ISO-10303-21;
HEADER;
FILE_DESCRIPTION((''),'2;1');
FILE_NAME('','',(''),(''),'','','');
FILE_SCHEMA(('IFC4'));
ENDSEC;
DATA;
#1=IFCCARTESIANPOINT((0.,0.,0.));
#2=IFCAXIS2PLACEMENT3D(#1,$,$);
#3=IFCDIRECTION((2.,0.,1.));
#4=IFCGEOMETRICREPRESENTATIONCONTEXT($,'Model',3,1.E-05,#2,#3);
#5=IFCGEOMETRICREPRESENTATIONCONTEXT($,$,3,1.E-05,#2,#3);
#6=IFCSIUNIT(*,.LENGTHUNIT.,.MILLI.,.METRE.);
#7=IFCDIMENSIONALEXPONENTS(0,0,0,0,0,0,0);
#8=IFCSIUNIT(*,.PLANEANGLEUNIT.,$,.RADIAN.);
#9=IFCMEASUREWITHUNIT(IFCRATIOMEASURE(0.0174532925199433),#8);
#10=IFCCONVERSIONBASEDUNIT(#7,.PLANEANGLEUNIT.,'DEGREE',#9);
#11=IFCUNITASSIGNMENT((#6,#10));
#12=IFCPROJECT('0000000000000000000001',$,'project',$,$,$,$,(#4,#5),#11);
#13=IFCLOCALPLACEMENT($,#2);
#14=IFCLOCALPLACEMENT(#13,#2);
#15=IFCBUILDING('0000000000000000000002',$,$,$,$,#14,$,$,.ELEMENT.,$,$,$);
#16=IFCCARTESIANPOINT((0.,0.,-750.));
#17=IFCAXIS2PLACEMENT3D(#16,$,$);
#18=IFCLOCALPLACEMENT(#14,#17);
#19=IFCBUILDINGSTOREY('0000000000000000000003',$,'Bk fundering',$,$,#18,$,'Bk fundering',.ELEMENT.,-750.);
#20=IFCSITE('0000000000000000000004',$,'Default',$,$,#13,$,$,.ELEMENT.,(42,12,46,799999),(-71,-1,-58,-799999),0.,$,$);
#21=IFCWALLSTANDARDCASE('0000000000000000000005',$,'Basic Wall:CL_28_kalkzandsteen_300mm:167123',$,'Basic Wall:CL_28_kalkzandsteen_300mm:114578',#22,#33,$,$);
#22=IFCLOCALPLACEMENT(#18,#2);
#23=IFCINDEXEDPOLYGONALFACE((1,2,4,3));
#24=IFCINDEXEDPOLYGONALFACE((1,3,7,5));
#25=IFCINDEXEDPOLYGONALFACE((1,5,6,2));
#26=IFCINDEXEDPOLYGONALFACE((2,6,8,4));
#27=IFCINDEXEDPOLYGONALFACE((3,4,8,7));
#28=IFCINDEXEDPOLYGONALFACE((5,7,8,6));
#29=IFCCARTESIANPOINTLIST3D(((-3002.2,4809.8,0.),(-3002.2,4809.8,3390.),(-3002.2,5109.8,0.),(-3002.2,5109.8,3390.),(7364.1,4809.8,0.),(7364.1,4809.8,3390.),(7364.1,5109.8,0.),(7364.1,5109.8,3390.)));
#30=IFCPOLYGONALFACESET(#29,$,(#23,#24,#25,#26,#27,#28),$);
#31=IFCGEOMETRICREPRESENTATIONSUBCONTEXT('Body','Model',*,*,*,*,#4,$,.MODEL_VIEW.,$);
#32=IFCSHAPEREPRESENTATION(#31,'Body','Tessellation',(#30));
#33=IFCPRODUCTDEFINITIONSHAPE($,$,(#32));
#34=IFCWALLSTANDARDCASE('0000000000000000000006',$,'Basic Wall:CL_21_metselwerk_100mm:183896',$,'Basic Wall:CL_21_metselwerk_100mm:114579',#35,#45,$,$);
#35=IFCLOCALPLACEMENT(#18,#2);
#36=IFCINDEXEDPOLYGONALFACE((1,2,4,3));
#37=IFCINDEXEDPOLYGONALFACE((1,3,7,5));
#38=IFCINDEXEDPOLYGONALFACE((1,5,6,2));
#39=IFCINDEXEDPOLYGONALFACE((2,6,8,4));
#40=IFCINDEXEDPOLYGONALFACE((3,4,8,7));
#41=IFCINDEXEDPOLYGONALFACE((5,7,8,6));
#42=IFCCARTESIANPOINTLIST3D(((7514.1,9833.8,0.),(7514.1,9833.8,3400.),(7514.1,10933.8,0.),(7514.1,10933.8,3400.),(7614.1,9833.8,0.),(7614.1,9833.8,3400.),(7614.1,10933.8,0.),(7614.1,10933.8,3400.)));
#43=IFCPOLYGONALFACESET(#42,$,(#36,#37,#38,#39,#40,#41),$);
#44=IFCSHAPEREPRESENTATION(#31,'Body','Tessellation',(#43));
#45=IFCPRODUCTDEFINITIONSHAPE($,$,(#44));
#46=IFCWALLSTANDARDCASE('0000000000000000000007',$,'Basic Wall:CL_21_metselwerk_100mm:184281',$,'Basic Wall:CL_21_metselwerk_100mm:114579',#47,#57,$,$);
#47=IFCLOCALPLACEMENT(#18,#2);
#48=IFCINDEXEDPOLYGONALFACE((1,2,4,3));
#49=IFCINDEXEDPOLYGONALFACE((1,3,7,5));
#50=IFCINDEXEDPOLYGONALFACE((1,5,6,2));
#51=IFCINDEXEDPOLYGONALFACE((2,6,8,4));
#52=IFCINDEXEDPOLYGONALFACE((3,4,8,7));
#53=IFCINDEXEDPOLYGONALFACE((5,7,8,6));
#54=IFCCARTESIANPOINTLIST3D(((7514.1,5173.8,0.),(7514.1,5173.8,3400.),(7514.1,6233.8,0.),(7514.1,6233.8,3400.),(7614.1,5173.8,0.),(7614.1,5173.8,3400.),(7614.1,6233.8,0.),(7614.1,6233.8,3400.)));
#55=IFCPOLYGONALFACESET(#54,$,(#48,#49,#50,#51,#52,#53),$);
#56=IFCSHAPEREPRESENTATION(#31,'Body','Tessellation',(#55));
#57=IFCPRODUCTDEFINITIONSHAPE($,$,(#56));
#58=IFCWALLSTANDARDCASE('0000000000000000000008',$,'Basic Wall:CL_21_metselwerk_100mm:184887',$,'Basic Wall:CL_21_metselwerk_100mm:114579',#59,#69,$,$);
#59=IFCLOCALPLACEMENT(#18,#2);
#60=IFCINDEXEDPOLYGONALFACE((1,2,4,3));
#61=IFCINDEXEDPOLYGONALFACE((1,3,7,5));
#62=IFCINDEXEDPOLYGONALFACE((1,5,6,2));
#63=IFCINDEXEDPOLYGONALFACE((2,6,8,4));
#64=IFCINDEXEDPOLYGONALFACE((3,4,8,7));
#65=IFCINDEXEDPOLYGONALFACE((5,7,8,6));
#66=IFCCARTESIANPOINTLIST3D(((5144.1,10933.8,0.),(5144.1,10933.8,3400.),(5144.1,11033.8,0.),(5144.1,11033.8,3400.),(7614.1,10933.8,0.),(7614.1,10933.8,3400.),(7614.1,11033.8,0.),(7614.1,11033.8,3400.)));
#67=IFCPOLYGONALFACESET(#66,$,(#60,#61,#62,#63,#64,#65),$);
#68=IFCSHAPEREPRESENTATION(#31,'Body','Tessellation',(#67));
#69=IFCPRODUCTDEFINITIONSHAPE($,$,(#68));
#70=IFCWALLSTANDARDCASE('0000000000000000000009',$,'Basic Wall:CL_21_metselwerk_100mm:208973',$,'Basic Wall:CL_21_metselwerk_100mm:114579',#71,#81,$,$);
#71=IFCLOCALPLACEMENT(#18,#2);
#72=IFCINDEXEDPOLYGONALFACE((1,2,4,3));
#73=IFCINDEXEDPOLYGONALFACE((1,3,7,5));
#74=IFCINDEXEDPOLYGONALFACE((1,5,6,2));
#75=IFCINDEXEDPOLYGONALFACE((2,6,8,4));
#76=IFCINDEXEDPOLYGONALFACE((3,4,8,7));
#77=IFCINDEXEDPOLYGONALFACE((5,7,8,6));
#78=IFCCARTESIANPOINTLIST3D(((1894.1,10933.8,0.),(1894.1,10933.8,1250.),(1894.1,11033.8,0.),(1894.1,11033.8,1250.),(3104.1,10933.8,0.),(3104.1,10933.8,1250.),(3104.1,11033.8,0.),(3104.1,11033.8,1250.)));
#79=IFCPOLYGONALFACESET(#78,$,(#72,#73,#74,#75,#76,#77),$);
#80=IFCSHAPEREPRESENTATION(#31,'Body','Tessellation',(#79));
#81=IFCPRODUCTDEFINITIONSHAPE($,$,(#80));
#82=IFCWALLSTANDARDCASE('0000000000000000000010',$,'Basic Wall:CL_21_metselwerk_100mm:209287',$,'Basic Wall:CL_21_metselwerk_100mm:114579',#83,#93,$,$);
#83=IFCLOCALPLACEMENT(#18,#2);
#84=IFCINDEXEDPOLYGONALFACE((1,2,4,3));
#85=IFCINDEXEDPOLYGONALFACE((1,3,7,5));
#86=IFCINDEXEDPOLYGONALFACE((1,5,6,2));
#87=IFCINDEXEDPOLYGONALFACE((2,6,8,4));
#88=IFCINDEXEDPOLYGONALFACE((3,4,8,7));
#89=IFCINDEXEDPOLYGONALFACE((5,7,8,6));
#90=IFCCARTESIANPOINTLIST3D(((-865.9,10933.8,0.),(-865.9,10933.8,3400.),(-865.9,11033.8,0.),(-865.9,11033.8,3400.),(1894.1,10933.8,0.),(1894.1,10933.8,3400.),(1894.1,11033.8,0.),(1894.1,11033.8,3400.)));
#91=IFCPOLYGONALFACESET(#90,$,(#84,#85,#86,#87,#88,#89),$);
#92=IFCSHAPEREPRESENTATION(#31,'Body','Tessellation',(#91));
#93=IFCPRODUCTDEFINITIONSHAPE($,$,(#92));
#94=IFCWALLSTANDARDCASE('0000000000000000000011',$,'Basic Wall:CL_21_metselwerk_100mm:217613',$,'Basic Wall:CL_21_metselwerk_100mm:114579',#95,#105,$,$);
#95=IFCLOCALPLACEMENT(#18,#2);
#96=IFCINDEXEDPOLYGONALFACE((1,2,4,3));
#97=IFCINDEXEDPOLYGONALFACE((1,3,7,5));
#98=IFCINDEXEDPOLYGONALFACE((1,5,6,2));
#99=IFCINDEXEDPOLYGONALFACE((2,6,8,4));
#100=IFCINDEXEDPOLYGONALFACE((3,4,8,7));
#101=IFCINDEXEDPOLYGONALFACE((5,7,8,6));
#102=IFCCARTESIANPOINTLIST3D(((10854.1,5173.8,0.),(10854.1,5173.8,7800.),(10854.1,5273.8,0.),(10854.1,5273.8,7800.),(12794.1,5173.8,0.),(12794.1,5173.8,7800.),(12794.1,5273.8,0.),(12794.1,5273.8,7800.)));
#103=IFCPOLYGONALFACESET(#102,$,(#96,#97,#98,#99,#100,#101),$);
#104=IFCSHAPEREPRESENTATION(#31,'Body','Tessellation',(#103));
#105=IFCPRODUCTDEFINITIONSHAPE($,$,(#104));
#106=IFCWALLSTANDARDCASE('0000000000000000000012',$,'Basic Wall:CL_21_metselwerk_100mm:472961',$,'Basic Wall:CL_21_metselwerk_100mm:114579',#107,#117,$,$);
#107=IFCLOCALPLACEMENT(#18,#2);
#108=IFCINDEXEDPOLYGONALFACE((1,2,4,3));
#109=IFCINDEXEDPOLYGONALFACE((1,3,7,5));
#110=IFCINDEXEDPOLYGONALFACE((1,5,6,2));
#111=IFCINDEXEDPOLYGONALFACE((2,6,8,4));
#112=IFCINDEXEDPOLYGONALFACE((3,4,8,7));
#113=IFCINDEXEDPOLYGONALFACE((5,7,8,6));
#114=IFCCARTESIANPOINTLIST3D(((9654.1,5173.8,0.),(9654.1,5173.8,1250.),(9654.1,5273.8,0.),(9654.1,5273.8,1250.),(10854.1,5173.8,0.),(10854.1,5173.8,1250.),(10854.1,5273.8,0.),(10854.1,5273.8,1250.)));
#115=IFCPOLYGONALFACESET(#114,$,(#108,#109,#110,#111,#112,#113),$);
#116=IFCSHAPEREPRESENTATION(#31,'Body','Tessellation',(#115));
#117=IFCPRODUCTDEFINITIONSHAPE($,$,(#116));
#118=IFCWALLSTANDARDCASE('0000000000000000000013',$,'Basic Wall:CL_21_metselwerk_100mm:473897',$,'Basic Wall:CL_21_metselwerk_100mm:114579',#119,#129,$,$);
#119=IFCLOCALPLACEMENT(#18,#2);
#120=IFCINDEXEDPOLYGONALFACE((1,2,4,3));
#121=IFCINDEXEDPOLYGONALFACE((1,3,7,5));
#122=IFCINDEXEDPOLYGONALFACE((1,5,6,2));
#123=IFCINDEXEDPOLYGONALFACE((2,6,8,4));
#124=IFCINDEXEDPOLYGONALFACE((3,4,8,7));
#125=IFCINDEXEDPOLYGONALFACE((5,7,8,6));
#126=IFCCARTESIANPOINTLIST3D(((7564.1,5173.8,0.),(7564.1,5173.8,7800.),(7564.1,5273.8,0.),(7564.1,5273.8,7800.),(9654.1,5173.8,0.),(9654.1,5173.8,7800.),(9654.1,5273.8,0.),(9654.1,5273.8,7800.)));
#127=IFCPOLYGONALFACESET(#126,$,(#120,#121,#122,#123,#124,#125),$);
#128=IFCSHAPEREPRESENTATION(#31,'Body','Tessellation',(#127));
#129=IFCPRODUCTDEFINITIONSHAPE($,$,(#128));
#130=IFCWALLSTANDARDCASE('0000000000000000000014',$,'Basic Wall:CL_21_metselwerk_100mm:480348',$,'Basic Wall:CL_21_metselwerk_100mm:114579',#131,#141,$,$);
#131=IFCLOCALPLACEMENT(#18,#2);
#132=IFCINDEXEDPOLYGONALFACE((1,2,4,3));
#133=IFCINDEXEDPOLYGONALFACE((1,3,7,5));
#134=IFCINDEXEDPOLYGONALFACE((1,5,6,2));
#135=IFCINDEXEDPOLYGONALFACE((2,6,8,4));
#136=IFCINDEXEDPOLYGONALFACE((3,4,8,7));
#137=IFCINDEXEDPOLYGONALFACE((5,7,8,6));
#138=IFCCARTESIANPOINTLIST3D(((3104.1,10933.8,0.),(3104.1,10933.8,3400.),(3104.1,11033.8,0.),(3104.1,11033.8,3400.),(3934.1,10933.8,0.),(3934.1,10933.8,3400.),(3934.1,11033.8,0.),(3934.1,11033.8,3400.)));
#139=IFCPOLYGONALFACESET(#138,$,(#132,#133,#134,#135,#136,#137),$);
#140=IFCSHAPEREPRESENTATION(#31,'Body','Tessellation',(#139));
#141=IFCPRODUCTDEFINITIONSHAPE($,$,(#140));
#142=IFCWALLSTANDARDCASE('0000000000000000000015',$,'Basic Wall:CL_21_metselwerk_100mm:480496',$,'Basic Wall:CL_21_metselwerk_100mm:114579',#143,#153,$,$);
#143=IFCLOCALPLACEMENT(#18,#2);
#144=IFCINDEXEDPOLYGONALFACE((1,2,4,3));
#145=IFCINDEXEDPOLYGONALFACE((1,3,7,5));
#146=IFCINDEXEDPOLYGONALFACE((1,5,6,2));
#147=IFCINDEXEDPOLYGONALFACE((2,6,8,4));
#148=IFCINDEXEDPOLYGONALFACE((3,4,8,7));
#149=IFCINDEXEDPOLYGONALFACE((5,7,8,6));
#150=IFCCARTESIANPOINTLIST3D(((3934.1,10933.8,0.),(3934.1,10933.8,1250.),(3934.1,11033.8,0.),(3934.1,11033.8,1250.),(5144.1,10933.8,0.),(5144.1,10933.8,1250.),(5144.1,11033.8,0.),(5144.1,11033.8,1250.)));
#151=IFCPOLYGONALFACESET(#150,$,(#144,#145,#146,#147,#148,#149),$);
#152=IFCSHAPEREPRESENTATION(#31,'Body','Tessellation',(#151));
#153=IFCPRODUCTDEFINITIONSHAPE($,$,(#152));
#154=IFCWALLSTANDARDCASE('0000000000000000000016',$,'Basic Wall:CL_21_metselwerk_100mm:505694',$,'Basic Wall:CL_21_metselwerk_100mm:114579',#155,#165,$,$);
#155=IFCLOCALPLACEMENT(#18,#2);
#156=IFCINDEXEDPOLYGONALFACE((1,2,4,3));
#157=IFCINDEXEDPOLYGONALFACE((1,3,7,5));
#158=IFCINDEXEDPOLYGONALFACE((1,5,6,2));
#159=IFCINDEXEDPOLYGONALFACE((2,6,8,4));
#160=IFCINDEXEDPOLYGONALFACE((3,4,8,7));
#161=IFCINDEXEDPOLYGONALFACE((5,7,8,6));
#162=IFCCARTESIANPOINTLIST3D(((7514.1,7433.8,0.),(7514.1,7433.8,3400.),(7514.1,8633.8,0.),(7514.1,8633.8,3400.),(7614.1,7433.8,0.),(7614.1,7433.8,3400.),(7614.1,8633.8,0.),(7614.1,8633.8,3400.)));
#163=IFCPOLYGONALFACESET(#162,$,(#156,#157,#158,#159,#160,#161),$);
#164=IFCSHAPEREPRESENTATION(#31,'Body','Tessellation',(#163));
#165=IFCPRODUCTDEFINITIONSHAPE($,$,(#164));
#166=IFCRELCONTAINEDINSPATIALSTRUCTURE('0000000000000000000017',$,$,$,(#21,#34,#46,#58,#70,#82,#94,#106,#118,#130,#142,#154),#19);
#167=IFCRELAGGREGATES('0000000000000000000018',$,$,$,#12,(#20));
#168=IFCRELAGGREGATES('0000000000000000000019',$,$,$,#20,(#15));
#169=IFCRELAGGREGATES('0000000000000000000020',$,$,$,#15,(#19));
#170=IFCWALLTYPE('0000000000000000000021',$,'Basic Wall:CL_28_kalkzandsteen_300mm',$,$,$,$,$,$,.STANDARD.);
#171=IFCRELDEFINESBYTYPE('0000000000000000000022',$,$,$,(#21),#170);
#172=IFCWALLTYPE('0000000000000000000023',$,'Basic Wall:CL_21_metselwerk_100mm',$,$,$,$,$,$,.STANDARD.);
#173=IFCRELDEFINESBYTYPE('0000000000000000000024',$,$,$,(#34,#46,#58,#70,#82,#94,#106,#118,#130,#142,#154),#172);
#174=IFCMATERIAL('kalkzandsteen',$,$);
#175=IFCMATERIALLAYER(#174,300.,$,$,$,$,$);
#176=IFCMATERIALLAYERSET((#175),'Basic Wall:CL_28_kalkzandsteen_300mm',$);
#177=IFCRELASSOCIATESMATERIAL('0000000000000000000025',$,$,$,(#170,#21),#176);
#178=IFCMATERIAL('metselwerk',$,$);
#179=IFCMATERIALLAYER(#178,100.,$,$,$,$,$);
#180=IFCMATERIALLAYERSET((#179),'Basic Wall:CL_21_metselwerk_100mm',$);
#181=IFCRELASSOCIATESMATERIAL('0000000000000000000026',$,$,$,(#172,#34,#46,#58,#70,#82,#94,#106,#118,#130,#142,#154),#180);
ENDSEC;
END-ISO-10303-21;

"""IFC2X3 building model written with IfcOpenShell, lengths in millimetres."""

from ifc_helpers import new_model, entity, si_unit, converted_unit, direction, frame, frame_2d, origin, place, context, subcontext, project, spatial, polyline, rectangle, extrude, clip, bounded_halfspace, material, layer, layer_set, layer_usage, type_object, element, save


model = new_model("IFC2X3")

# Units and contexts
model_context = context("Model", 3, precision=1e-05, world=origin(), true_north=direction((2.0, 0.0, 1.0)))
context_of_model = context(None, 3, precision=1e-05, world=origin(), true_north=direction((2.0, 0.0, 1.0)))
body_context = subcontext(model_context, "Body", "Model", "MODEL_VIEW")
ifc_project = project(units=[si_unit("LENGTHUNIT", "METRE", prefix="MILLI"), converted_unit("PLANEANGLEUNIT", "DEGREE", entity("IfcRatioMeasure", 0.0174532925199433), si_unit("PLANEANGLEUNIT", "RADIAN"), dimensions=[0, 0, 0, 0, 0, 0, 0])], contexts=[model_context, context_of_model])

# Site, building, storey
site_placement = place(None, origin())
site = spatial("IfcSite", under=ifc_project, at=site_placement, Name="Default", CompositionType="ELEMENT", RefLatitude=(42, 12, 46, 799999), RefLongitude=(-71, -1, -58, -799999), RefElevation=0.0)
building_placement = place(site_placement, origin())
building = spatial("IfcBuilding", under=site, at=building_placement, CompositionType="ELEMENT")
storey_placement = place(building_placement, frame((0.0, 0.0, -750.0)))
storey = spatial("IfcBuildingStorey", under=building, at=storey_placement, Name="Bk fundering", LongName="Bk fundering", CompositionType="ELEMENT", Elevation=-750.0)

# Shared definitions
ifc_material_1 = material(Name="kalkzandsteen")

# Walls
ifc_layer_1 = layer(ifc_material_1, 300.0)
ifc_layer_set_1 = layer_set([ifc_layer_1], Name="Basic Wall:CL_28_kalkzandsteen_300mm")
ifc_layer_usage_1 = layer_usage(ifc_layer_set_1, "AXIS2", "NEGATIVE", 150.0)
wall_type_1 = type_object("IfcWallType", Name="Basic Wall:CL_28_kalkzandsteen_300mm", PredefinedType="STANDARD", material=ifc_layer_set_1)
wall_1_placement = place(storey_placement, frame((7364.1, 4959.8, 0.0), z_axis=(0.0, 0.0, 1.0), x_axis=(-1.0, 0.0, 0.0)))
element("IfcWallStandardCase", 1, at=wall_1_placement, inside=storey, type_object=wall_type_1, material=ifc_layer_usage_1, Name="Basic Wall:CL_28_kalkzandsteen_300mm:167123", ObjectType="Basic Wall:CL_28_kalkzandsteen_300mm:114578", context=body_context, shape_type="SweptSolid", body=[
    extrude(rectangle(XDim=10366.3, YDim=300.0, at=frame_2d((5183.1, 0.0), x_axis=(-1.0, 0.0))), origin(), (0.0, 0.0, 1.0), 3390.0),
])
ifc_material_2 = material(Name="metselwerk")
ifc_layer_2 = layer(ifc_material_2, 100.0)
ifc_layer_set_2 = layer_set([ifc_layer_2], Name="Basic Wall:CL_21_metselwerk_100mm")
ifc_layer_usage_2 = layer_usage(ifc_layer_set_2, "AXIS2", "NEGATIVE", 50.0)
wall_type_2 = type_object("IfcWallType", Name="Basic Wall:CL_21_metselwerk_100mm", PredefinedType="STANDARD", material=ifc_layer_set_2)
wall_2_placement = place(storey_placement, frame((7564.1, 9833.8, 0.0), z_axis=(0.0, 0.0, 1.0), x_axis=(0.0, 1.0, 0.0)))
element("IfcWallStandardCase", 2, at=wall_2_placement, inside=storey, type_object=wall_type_2, material=ifc_layer_usage_2, Name="Basic Wall:CL_21_metselwerk_100mm:183896", ObjectType="Basic Wall:CL_21_metselwerk_100mm:114579", context=body_context, shape_type="SweptSolid", body=[
    extrude(rectangle(XDim=1100.0, YDim=100.0, at=frame_2d((550.0, 0.0), x_axis=(-1.0, 0.0))), origin(), (0.0, 0.0, 1.0), 3400.0),
])
ifc_layer_usage_3 = layer_usage(ifc_layer_set_2, "AXIS2", "NEGATIVE", 50.0)
wall_3_placement = place(storey_placement, frame((7564.1, 5173.8, 0.0), z_axis=(0.0, 0.0, 1.0), x_axis=(0.0, 1.0, 0.0)))
element("IfcWallStandardCase", 3, at=wall_3_placement, inside=storey, type_object=wall_type_2, material=ifc_layer_usage_3, Name="Basic Wall:CL_21_metselwerk_100mm:184281", ObjectType="Basic Wall:CL_21_metselwerk_100mm:114579", context=body_context, shape_type="SweptSolid", body=[
    extrude(rectangle(XDim=1060.0, YDim=100.0, at=frame_2d((530.0, 0.0), x_axis=(-1.0, 0.0))), origin(), (0.0, 0.0, 1.0), 3400.0),
])
ifc_layer_usage_4 = layer_usage(ifc_layer_set_2, "AXIS2", "NEGATIVE", 50.0)
wall_4_placement = place(storey_placement, frame((7614.1, 10983.8, 0.0), z_axis=(0.0, 0.0, 1.0), x_axis=(-1.0, 0.0, 0.0)))
element("IfcWallStandardCase", 4, at=wall_4_placement, inside=storey, type_object=wall_type_2, material=ifc_layer_usage_4, Name="Basic Wall:CL_21_metselwerk_100mm:184887", ObjectType="Basic Wall:CL_21_metselwerk_100mm:114579", context=body_context, shape_type="SweptSolid", body=[
    extrude(rectangle(XDim=2470.0, YDim=100.0, at=frame_2d((1235.0, 0.0), x_axis=(-1.0, 0.0))), origin(), (0.0, 0.0, 1.0), 3400.0),
])
ifc_layer_usage_5 = layer_usage(ifc_layer_set_2, "AXIS2", "NEGATIVE", 50.0)
wall_5_placement = place(storey_placement, frame((3104.1, 10983.8, 0.0), z_axis=(0.0, 0.0, 1.0), x_axis=(-1.0, 0.0, 0.0)))
element("IfcWallStandardCase", 5, at=wall_5_placement, inside=storey, type_object=wall_type_2, material=ifc_layer_usage_5, Name="Basic Wall:CL_21_metselwerk_100mm:208973", ObjectType="Basic Wall:CL_21_metselwerk_100mm:114579", context=body_context, shape_type="SweptSolid", body=[
    extrude(rectangle(XDim=1210.0, YDim=100.0, at=frame_2d((605.0, 0.0), x_axis=(-1.0, 0.0))), origin(), (0.0, 0.0, 1.0), 1250.0),
])
ifc_layer_usage_6 = layer_usage(ifc_layer_set_2, "AXIS2", "NEGATIVE", 50.0)
wall_6_placement = place(storey_placement, frame((1894.1, 10983.8, 0.0), z_axis=(0.0, 0.0, 1.0), x_axis=(-1.0, 0.0, 0.0)))
element("IfcWallStandardCase", 6, at=wall_6_placement, inside=storey, type_object=wall_type_2, material=ifc_layer_usage_6, Name="Basic Wall:CL_21_metselwerk_100mm:209287", ObjectType="Basic Wall:CL_21_metselwerk_100mm:114579", context=body_context, shape_type="Clipping", body=[
    clip(extrude(rectangle(XDim=2760.0, YDim=100.0, at=frame_2d((1380.0, 0.0), x_axis=(-1.0, 0.0))), origin(), (0.0, 0.0, 1.0), 3400.0), bounded_halfspace(frame((2760.0, -50.0, 0.0), z_axis=(0.0, 0.0, 1.0), x_axis=(0.0, -1.0, 0.0)), True, frame((2760.0, -50.0, 0.0)), polyline([(0.0, 0.0), (0.0, 100.0), (-2760.0, 100.0), (-2760.0, 0.0), (0.0, 0.0)]))),
])
ifc_layer_usage_7 = layer_usage(ifc_layer_set_2, "AXIS2", "NEGATIVE", 50.0)
wall_7_placement = place(storey_placement, frame((12794.1, 5223.8, 0.0), z_axis=(0.0, 0.0, 1.0), x_axis=(-1.0, 0.0, 0.0)))
element("IfcWallStandardCase", 7, at=wall_7_placement, inside=storey, type_object=wall_type_2, material=ifc_layer_usage_7, Name="Basic Wall:CL_21_metselwerk_100mm:217613", ObjectType="Basic Wall:CL_21_metselwerk_100mm:114579", context=body_context, shape_type="SweptSolid", body=[
    extrude(rectangle(XDim=1940.0, YDim=100.0, at=frame_2d((970.0, 0.0), x_axis=(-1.0, 0.0))), origin(), (0.0, 0.0, 1.0), 7800.0),
])
ifc_layer_usage_8 = layer_usage(ifc_layer_set_2, "AXIS2", "NEGATIVE", 50.0)
wall_8_placement = place(storey_placement, frame((9654.1, 5223.8, 0.0)))
element("IfcWallStandardCase", 8, at=wall_8_placement, inside=storey, type_object=wall_type_2, material=ifc_layer_usage_8, Name="Basic Wall:CL_21_metselwerk_100mm:472961", ObjectType="Basic Wall:CL_21_metselwerk_100mm:114579", context=body_context, shape_type="SweptSolid", body=[
    extrude(rectangle(XDim=1200.0, YDim=100.0, at=frame_2d((600.0, 0.0), x_axis=(-1.0, 0.0))), origin(), (0.0, 0.0, 1.0), 1250.0),
])
ifc_layer_usage_9 = layer_usage(ifc_layer_set_2, "AXIS2", "NEGATIVE", 50.0)
wall_9_placement = place(storey_placement, frame((9654.1, 5223.8, 0.0), z_axis=(0.0, 0.0, 1.0), x_axis=(-1.0, 0.0, 0.0)))
element("IfcWallStandardCase", 9, at=wall_9_placement, inside=storey, type_object=wall_type_2, material=ifc_layer_usage_9, Name="Basic Wall:CL_21_metselwerk_100mm:473897", ObjectType="Basic Wall:CL_21_metselwerk_100mm:114579", context=body_context, shape_type="SweptSolid", body=[
    extrude(rectangle(XDim=2090.0, YDim=100.0, at=frame_2d((1045.0, 0.0), x_axis=(-1.0, 0.0))), origin(), (0.0, 0.0, 1.0), 7800.0),
])
ifc_layer_usage_10 = layer_usage(ifc_layer_set_2, "AXIS2", "NEGATIVE", 50.0)
wall_10_placement = place(storey_placement, frame((3934.1, 10983.8, 0.0), z_axis=(0.0, 0.0, 1.0), x_axis=(-1.0, 0.0, 0.0)))
element("IfcWallStandardCase", 10, at=wall_10_placement, inside=storey, type_object=wall_type_2, material=ifc_layer_usage_10, Name="Basic Wall:CL_21_metselwerk_100mm:480348", ObjectType="Basic Wall:CL_21_metselwerk_100mm:114579", context=body_context, shape_type="SweptSolid", body=[
    extrude(rectangle(XDim=830.0, YDim=100.0, at=frame_2d((415.0, 0.0), x_axis=(-1.0, 0.0))), origin(), (0.0, 0.0, 1.0), 3400.0),
])
ifc_layer_usage_11 = layer_usage(ifc_layer_set_2, "AXIS2", "NEGATIVE", 50.0)
wall_11_placement = place(storey_placement, frame((5144.1, 10983.8, 0.0), z_axis=(0.0, 0.0, 1.0), x_axis=(-1.0, 0.0, 0.0)))
element("IfcWallStandardCase", 11, at=wall_11_placement, inside=storey, type_object=wall_type_2, material=ifc_layer_usage_11, Name="Basic Wall:CL_21_metselwerk_100mm:480496", ObjectType="Basic Wall:CL_21_metselwerk_100mm:114579", context=body_context, shape_type="SweptSolid", body=[
    extrude(rectangle(XDim=1210.0, YDim=100.0, at=frame_2d((605.0, 0.0), x_axis=(-1.0, 0.0))), origin(), (0.0, 0.0, 1.0), 1250.0),
])
ifc_layer_usage_12 = layer_usage(ifc_layer_set_2, "AXIS2", "NEGATIVE", 50.0)
wall_12_placement = place(storey_placement, frame((7564.1, 7433.8, 0.0), z_axis=(0.0, 0.0, 1.0), x_axis=(0.0, 1.0, 0.0)))
element("IfcWallStandardCase", 12, at=wall_12_placement, inside=storey, type_object=wall_type_2, material=ifc_layer_usage_12, Name="Basic Wall:CL_21_metselwerk_100mm:505694", ObjectType="Basic Wall:CL_21_metselwerk_100mm:114579", context=body_context, shape_type="SweptSolid", body=[
    extrude(rectangle(XDim=1200.0, YDim=100.0, at=frame_2d((600.0, 0.0), x_axis=(-1.0, 0.0))), origin(), (0.0, 0.0, 1.0), 3400.0),
])

save(model, "model.ifc")
